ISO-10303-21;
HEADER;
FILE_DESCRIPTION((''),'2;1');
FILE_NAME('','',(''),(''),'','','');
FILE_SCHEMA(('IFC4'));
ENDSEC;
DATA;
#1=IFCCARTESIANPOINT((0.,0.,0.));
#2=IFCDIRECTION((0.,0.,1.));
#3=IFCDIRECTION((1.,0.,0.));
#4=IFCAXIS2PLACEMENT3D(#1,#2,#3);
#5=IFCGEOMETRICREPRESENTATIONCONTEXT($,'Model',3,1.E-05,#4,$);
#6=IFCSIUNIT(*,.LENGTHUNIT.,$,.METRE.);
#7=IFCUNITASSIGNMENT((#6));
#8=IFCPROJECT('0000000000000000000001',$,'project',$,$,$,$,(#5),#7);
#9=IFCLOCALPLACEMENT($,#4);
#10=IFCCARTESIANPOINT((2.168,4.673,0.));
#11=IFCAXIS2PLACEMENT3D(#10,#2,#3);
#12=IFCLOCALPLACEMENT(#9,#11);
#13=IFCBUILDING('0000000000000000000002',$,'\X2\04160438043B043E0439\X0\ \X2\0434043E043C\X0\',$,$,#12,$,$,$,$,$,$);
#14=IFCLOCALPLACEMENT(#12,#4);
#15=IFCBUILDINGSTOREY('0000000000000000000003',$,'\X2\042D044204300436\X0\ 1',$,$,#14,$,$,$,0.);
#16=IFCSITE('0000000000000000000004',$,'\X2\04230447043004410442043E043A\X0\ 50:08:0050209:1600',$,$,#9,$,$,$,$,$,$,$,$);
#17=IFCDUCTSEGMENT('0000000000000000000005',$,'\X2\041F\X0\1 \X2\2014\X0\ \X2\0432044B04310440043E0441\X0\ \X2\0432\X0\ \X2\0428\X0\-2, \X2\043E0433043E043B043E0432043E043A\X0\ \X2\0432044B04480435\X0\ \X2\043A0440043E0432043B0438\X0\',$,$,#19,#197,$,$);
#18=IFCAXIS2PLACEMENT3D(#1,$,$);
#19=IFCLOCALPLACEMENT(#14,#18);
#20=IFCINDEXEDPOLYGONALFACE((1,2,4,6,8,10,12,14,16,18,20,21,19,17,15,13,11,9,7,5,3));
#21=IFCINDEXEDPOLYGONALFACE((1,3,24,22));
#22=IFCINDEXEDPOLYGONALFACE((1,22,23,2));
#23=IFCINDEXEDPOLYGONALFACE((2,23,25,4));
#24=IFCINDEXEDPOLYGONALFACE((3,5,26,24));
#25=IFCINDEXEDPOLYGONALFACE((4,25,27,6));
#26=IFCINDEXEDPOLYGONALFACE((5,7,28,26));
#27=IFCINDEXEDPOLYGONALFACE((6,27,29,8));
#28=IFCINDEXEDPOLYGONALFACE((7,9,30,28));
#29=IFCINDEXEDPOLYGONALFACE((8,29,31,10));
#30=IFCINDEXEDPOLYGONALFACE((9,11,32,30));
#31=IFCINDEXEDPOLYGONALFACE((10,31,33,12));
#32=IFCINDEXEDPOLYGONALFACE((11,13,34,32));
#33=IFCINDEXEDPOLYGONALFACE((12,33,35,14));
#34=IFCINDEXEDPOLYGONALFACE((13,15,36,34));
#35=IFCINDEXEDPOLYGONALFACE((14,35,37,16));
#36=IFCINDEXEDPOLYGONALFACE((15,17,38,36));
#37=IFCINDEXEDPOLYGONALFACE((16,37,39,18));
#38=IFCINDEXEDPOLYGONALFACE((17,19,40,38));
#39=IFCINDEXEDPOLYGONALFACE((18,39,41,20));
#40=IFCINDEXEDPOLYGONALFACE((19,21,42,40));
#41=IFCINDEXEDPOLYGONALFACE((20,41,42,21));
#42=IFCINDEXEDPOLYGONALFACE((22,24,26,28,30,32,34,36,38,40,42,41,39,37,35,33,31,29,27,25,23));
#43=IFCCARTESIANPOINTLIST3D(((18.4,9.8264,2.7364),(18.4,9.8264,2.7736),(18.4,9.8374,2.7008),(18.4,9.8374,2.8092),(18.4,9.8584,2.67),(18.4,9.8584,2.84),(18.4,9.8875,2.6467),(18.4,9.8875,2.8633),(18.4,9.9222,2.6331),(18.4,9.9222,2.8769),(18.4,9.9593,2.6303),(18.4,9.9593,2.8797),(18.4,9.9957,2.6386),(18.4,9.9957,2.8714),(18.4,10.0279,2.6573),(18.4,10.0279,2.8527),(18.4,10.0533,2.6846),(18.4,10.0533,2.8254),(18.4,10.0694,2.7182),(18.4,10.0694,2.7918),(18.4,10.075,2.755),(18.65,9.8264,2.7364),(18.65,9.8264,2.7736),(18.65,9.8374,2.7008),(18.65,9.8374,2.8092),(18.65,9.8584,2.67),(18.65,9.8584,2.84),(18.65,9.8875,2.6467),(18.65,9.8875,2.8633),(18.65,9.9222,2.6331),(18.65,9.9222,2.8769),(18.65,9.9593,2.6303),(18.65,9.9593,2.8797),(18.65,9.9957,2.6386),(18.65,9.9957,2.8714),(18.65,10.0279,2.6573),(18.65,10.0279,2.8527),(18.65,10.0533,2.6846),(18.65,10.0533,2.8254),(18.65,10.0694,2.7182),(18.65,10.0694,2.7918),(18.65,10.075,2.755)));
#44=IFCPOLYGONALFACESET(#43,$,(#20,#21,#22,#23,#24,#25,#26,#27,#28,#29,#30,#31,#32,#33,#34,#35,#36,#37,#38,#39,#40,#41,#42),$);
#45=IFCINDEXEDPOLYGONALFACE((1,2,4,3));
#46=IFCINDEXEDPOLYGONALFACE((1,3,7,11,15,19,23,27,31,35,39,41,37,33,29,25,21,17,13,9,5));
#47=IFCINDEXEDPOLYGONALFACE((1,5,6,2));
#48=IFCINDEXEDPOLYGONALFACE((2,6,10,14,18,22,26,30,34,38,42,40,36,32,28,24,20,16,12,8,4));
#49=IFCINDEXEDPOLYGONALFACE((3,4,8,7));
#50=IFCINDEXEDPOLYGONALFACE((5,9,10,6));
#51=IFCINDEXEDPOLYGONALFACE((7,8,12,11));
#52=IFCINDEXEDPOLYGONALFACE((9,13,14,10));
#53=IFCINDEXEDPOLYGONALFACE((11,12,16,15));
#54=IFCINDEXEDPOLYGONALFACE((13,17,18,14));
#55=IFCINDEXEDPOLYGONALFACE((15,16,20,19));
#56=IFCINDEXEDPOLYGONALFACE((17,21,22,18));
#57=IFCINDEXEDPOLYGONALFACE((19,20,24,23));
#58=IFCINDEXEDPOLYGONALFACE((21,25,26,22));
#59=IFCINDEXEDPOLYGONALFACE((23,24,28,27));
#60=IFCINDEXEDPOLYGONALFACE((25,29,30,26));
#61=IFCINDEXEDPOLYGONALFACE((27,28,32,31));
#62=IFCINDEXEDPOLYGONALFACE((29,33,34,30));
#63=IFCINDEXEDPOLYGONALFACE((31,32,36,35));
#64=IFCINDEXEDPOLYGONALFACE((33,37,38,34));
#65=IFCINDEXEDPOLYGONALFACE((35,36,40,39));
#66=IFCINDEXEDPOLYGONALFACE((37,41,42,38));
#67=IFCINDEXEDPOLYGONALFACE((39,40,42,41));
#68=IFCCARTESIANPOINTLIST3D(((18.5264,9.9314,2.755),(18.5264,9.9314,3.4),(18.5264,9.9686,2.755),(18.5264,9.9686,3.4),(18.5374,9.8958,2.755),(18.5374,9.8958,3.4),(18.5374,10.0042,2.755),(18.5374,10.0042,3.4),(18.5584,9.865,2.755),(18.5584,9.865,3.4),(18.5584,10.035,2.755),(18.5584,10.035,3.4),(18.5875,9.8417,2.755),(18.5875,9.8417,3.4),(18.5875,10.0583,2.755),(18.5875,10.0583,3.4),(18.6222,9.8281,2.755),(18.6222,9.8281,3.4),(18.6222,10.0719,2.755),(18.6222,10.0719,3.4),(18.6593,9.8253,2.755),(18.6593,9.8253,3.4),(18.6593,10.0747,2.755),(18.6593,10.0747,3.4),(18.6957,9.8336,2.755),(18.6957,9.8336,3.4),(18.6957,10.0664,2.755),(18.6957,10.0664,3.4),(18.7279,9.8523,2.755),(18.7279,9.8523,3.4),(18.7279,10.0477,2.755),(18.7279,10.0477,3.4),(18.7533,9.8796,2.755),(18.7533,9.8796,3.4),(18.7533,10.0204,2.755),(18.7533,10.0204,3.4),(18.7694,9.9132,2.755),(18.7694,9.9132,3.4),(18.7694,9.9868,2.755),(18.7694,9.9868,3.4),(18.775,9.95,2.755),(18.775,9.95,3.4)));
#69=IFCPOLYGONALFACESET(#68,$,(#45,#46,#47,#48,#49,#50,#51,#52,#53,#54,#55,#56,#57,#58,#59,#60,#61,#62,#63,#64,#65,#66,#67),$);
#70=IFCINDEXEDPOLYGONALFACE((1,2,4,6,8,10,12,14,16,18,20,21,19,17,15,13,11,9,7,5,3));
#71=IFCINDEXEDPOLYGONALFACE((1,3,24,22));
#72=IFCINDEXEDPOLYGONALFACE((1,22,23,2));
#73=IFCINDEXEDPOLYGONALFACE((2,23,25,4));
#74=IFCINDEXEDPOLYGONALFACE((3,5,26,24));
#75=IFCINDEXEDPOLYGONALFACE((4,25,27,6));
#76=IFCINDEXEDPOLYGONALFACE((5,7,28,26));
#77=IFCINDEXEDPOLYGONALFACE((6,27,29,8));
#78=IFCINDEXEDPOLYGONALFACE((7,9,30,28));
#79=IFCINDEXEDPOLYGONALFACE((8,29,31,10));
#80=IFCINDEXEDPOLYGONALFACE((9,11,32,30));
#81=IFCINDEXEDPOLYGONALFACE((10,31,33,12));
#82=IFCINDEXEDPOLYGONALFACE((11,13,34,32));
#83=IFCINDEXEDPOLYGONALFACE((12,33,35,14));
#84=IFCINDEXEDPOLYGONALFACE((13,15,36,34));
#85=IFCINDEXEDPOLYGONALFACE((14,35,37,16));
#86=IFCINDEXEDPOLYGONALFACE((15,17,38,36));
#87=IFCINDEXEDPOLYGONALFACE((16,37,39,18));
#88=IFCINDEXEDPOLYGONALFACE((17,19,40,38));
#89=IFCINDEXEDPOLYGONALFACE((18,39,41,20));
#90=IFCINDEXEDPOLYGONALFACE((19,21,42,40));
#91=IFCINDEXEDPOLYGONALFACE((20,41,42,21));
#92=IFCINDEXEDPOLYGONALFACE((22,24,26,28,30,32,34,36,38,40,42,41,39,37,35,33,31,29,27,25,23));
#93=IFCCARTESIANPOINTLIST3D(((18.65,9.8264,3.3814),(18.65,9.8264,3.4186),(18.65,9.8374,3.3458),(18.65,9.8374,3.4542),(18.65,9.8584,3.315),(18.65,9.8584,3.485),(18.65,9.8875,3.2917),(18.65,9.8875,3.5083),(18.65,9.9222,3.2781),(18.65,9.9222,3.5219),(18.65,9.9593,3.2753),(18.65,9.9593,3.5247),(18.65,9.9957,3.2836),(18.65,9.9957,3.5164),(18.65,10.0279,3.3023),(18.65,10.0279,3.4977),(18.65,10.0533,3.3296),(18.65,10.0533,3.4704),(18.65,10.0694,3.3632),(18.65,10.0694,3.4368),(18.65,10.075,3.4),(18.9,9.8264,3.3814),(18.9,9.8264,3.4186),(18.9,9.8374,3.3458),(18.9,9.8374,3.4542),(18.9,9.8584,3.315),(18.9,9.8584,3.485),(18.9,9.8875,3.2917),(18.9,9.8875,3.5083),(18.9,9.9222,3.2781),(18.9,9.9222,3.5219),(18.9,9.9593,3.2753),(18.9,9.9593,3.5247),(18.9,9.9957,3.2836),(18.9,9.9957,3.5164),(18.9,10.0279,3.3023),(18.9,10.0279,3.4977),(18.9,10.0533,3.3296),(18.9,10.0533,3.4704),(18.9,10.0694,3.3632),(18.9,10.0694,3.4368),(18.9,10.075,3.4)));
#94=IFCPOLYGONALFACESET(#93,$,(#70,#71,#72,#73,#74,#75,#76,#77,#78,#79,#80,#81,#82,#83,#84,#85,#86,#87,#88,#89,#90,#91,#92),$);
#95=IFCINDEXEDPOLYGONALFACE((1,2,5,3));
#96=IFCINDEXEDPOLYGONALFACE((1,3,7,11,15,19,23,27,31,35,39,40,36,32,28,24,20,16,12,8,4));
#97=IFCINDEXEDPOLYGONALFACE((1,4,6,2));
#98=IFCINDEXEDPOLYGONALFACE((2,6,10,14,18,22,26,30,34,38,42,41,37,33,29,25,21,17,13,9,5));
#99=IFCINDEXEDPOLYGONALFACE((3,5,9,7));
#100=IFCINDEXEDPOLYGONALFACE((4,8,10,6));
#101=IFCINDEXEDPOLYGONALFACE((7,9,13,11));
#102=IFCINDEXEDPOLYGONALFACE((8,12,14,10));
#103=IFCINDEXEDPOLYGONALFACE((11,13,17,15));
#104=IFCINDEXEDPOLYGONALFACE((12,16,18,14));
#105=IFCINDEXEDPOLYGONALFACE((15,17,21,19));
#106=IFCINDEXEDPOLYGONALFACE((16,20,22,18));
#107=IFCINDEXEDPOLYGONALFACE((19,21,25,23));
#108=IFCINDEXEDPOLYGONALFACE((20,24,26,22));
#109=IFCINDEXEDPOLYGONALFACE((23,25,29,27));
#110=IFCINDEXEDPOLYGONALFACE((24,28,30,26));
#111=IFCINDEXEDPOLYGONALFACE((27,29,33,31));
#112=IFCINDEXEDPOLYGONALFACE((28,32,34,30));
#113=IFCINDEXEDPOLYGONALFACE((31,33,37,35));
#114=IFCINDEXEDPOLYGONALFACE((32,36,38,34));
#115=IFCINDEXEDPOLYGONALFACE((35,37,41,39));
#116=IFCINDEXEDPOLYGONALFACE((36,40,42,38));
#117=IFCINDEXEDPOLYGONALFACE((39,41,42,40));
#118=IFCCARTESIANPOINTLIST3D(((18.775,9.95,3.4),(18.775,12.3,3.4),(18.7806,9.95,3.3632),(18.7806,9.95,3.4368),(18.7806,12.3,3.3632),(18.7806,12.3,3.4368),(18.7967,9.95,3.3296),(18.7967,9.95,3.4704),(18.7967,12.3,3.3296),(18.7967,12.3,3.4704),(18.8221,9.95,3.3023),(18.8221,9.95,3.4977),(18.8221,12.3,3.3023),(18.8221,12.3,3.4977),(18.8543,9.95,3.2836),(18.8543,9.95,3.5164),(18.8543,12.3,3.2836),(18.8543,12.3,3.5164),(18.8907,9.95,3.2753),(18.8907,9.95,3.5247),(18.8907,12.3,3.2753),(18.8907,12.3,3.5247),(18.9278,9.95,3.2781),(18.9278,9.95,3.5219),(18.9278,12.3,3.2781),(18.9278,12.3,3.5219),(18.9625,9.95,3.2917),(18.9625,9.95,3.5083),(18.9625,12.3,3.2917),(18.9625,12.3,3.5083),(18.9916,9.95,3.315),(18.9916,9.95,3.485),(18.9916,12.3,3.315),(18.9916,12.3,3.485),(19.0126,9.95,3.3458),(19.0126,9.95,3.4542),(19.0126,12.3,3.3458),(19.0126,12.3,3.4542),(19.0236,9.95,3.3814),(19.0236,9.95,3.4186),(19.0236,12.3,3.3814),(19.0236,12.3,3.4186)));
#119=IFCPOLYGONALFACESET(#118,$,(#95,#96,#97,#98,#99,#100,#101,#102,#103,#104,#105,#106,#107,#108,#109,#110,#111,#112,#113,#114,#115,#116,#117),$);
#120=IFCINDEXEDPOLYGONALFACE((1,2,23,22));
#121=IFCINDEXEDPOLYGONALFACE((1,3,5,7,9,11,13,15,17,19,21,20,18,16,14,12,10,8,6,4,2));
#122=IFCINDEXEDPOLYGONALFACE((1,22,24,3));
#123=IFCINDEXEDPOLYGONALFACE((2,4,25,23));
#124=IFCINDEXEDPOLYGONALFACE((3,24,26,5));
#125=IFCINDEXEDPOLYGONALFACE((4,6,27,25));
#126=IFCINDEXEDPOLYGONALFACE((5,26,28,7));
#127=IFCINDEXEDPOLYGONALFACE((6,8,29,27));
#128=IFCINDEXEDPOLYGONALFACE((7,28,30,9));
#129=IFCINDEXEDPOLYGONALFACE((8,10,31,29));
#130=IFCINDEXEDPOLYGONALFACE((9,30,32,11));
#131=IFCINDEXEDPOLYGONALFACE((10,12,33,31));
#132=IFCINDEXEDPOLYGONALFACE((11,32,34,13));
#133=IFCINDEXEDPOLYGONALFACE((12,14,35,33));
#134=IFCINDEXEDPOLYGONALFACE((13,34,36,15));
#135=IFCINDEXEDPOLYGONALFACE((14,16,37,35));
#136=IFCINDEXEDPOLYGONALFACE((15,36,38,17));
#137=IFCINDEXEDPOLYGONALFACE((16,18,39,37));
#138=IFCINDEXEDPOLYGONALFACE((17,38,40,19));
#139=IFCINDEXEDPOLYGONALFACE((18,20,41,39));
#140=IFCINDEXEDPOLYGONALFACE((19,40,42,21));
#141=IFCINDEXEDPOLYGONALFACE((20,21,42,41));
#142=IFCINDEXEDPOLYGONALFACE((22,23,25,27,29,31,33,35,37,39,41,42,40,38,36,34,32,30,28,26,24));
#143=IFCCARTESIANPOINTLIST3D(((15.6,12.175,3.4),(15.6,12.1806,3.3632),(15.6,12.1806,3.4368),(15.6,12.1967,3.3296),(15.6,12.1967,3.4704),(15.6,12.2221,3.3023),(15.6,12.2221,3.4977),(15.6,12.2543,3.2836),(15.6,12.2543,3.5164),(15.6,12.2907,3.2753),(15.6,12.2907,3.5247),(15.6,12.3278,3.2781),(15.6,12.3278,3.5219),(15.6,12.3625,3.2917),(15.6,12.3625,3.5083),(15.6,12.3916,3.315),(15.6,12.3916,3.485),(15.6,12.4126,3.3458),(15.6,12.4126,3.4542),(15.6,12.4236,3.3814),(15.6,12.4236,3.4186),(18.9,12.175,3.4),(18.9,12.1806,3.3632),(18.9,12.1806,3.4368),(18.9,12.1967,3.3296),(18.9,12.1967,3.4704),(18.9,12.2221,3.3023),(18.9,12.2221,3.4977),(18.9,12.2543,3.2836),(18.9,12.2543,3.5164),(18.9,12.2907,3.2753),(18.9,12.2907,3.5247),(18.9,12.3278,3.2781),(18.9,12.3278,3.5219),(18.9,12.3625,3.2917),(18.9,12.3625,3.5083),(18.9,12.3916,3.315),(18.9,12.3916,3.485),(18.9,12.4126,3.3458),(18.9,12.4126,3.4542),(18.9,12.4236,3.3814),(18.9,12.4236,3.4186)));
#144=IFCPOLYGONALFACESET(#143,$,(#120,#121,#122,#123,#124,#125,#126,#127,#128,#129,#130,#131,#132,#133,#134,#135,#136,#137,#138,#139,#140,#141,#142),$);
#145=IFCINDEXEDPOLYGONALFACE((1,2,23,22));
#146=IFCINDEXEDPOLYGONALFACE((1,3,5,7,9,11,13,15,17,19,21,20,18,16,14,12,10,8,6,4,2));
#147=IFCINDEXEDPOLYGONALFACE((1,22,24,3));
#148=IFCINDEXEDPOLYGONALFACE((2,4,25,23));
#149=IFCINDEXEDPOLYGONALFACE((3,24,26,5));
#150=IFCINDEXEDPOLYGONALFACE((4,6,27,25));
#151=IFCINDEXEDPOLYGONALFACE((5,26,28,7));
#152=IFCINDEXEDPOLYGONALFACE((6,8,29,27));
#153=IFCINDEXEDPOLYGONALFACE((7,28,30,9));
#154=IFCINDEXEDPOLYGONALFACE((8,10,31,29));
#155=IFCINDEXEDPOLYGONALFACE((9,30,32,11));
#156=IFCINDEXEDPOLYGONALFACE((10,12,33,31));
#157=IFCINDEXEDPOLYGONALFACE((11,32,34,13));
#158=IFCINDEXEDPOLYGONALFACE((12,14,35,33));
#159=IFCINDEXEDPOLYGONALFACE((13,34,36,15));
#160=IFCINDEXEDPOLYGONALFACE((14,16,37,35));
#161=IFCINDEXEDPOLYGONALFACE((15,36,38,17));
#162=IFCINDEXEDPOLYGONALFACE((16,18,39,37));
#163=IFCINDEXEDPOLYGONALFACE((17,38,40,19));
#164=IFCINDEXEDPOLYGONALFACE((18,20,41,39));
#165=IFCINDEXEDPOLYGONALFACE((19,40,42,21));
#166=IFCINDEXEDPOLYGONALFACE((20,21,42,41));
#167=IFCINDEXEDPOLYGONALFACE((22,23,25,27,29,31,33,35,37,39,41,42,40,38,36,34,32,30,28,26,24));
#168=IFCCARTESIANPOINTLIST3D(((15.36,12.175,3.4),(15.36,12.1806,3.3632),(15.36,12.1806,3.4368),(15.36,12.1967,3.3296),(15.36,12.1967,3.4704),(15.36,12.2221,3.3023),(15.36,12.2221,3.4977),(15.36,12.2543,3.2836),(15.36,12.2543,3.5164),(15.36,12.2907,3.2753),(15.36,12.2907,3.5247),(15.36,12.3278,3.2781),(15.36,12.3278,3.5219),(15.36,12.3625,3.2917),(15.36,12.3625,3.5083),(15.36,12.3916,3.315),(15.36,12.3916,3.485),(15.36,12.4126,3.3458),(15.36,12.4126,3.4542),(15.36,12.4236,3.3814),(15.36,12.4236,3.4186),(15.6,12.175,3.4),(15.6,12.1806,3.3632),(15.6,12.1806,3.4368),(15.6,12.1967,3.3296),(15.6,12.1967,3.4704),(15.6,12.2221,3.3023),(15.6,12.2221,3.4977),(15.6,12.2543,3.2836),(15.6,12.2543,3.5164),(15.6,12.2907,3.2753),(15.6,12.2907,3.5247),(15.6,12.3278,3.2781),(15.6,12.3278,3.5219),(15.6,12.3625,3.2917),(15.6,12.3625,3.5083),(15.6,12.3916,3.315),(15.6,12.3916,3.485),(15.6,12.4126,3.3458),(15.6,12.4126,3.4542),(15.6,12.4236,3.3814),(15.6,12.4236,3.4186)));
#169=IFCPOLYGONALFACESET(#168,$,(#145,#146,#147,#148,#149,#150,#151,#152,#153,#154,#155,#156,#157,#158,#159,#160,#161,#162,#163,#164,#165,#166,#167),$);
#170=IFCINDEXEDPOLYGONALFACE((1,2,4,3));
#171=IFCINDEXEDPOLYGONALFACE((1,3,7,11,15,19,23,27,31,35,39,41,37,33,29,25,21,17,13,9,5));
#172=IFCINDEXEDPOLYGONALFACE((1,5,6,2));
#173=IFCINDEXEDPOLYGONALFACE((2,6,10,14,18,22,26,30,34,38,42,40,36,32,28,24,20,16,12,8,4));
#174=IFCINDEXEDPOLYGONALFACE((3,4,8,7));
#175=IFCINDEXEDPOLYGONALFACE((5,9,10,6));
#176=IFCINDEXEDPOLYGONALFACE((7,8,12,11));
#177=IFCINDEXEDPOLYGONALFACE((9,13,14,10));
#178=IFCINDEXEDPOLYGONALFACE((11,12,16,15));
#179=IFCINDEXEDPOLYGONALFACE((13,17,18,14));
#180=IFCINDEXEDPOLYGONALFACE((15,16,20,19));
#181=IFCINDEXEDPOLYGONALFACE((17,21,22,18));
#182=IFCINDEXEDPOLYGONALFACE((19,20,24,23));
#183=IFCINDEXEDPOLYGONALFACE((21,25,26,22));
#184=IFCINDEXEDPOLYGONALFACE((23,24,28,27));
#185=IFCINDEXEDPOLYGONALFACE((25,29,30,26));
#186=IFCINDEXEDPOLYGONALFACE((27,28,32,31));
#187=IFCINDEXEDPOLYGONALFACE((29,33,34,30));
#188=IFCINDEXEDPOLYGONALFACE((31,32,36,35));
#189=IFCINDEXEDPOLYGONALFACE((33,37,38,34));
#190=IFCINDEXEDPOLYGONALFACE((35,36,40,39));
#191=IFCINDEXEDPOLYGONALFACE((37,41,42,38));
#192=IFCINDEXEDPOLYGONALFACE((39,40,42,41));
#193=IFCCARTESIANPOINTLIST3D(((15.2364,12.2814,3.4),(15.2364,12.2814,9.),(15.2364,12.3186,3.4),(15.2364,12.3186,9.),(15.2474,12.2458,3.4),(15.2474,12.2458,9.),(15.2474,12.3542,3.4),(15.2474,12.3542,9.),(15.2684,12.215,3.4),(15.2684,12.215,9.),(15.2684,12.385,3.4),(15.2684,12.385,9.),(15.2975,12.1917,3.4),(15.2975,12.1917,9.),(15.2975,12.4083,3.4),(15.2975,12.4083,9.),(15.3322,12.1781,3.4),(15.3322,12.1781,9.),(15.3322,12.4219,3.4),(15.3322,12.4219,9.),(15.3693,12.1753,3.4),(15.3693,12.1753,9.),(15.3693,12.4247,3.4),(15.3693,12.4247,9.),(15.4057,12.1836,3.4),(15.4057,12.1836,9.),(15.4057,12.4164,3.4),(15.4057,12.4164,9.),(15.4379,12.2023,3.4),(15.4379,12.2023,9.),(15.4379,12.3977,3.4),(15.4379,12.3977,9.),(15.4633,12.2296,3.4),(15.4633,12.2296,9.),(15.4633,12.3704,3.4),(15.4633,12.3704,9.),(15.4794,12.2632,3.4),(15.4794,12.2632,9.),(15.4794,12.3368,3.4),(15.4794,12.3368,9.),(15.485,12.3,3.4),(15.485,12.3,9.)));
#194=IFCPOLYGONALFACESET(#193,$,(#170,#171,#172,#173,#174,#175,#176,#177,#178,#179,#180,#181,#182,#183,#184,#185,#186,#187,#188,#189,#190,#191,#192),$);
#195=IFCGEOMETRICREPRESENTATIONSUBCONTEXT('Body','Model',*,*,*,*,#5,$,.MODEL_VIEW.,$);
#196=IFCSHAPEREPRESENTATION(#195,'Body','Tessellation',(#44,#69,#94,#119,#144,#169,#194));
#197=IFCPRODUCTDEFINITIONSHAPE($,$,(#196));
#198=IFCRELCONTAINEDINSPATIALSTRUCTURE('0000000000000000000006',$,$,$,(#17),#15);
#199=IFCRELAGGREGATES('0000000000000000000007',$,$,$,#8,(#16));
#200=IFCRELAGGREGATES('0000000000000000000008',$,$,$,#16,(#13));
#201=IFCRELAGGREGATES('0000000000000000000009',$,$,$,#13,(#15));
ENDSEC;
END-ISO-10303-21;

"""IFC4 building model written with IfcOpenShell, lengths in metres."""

from ifc_helpers import new_model, si_unit, frame, origin_with_axes, origin_2d, place, context, subcontext, project, spatial, circle, extrude, element, save


model = new_model("IFC4")

# Units and contexts
model_context = context("Model", 3, precision=1e-05, world=origin_with_axes())
body_context = subcontext(model_context, "Body", "Model", "MODEL_VIEW")
ifc_project = project(units=[si_unit("LENGTHUNIT", "METRE")], contexts=[model_context])

# Site, building, storey
site_placement = place(None, origin_with_axes())
site = spatial("IfcSite", under=ifc_project, at=site_placement, Name="Участок 50:08:0050209:1600")
building_placement = place(site_placement, frame((2.168, 4.673, 0.0), z_axis=(0.0, 0.0, 1.0), x_axis=(1.0, 0.0, 0.0)))
building = spatial("IfcBuilding", under=site, at=building_placement, Name="Жилой дом")
storey_placement = place(building_placement, origin_with_axes())
storey = spatial("IfcBuildingStorey", under=building, at=storey_placement, Name="Этаж 1", Elevation=0.0)

# Duct segment
duct_segment_1_placement = place(storey_placement, origin_with_axes())
element("IfcDuctSegment", 1, at=duct_segment_1_placement, inside=storey, Name="П1 — выброс в Ш-2, оголовок выше кровли", context=body_context, shape_type="SweptSolid", body=[
    extrude(circle(Radius=0.125, at=origin_2d()), frame((18.4, 9.95, 2.755), z_axis=(1.0, 0.0, 0.0), x_axis=(0.0, 1.0, 0.0)), (0.0, 0.0, 1.0), 0.25),
    extrude(circle(Radius=0.125, at=origin_2d()), frame((18.65, 9.95, 2.755), z_axis=(0.0, 0.0, 1.0), x_axis=(1.0, 0.0, 0.0)), (0.0, 0.0, 1.0), 0.645),
    extrude(circle(Radius=0.125, at=origin_2d()), frame((18.65, 9.95, 3.4), z_axis=(1.0, 0.0, 0.0), x_axis=(0.0, 1.0, 0.0)), (0.0, 0.0, 1.0), 0.25),
    extrude(circle(Radius=0.125, at=origin_2d()), frame((18.9, 9.95, 3.4), z_axis=(0.0, 1.0, 0.0), x_axis=(-1.0, 0.0, 0.0)), (0.0, 0.0, 1.0), 2.35),
    extrude(circle(Radius=0.125, at=origin_2d()), frame((18.9, 12.3, 3.4), z_axis=(-1.0, 0.0, 0.0), x_axis=(0.0, -1.0, 0.0)), (0.0, 0.0, 1.0), 3.3),
    extrude(circle(Radius=0.125, at=origin_2d()), frame((15.6, 12.3, 3.4), z_axis=(-1.0, 0.0, 0.0), x_axis=(0.0, -1.0, 0.0)), (0.0, 0.0, 1.0), 0.24),
    extrude(circle(Radius=0.125, at=origin_2d()), frame((15.36, 12.3, 3.4), z_axis=(0.0, 0.0, 1.0), x_axis=(1.0, 0.0, 0.0)), (0.0, 0.0, 1.0), 5.6),
])

save(model, "model.ifc")
